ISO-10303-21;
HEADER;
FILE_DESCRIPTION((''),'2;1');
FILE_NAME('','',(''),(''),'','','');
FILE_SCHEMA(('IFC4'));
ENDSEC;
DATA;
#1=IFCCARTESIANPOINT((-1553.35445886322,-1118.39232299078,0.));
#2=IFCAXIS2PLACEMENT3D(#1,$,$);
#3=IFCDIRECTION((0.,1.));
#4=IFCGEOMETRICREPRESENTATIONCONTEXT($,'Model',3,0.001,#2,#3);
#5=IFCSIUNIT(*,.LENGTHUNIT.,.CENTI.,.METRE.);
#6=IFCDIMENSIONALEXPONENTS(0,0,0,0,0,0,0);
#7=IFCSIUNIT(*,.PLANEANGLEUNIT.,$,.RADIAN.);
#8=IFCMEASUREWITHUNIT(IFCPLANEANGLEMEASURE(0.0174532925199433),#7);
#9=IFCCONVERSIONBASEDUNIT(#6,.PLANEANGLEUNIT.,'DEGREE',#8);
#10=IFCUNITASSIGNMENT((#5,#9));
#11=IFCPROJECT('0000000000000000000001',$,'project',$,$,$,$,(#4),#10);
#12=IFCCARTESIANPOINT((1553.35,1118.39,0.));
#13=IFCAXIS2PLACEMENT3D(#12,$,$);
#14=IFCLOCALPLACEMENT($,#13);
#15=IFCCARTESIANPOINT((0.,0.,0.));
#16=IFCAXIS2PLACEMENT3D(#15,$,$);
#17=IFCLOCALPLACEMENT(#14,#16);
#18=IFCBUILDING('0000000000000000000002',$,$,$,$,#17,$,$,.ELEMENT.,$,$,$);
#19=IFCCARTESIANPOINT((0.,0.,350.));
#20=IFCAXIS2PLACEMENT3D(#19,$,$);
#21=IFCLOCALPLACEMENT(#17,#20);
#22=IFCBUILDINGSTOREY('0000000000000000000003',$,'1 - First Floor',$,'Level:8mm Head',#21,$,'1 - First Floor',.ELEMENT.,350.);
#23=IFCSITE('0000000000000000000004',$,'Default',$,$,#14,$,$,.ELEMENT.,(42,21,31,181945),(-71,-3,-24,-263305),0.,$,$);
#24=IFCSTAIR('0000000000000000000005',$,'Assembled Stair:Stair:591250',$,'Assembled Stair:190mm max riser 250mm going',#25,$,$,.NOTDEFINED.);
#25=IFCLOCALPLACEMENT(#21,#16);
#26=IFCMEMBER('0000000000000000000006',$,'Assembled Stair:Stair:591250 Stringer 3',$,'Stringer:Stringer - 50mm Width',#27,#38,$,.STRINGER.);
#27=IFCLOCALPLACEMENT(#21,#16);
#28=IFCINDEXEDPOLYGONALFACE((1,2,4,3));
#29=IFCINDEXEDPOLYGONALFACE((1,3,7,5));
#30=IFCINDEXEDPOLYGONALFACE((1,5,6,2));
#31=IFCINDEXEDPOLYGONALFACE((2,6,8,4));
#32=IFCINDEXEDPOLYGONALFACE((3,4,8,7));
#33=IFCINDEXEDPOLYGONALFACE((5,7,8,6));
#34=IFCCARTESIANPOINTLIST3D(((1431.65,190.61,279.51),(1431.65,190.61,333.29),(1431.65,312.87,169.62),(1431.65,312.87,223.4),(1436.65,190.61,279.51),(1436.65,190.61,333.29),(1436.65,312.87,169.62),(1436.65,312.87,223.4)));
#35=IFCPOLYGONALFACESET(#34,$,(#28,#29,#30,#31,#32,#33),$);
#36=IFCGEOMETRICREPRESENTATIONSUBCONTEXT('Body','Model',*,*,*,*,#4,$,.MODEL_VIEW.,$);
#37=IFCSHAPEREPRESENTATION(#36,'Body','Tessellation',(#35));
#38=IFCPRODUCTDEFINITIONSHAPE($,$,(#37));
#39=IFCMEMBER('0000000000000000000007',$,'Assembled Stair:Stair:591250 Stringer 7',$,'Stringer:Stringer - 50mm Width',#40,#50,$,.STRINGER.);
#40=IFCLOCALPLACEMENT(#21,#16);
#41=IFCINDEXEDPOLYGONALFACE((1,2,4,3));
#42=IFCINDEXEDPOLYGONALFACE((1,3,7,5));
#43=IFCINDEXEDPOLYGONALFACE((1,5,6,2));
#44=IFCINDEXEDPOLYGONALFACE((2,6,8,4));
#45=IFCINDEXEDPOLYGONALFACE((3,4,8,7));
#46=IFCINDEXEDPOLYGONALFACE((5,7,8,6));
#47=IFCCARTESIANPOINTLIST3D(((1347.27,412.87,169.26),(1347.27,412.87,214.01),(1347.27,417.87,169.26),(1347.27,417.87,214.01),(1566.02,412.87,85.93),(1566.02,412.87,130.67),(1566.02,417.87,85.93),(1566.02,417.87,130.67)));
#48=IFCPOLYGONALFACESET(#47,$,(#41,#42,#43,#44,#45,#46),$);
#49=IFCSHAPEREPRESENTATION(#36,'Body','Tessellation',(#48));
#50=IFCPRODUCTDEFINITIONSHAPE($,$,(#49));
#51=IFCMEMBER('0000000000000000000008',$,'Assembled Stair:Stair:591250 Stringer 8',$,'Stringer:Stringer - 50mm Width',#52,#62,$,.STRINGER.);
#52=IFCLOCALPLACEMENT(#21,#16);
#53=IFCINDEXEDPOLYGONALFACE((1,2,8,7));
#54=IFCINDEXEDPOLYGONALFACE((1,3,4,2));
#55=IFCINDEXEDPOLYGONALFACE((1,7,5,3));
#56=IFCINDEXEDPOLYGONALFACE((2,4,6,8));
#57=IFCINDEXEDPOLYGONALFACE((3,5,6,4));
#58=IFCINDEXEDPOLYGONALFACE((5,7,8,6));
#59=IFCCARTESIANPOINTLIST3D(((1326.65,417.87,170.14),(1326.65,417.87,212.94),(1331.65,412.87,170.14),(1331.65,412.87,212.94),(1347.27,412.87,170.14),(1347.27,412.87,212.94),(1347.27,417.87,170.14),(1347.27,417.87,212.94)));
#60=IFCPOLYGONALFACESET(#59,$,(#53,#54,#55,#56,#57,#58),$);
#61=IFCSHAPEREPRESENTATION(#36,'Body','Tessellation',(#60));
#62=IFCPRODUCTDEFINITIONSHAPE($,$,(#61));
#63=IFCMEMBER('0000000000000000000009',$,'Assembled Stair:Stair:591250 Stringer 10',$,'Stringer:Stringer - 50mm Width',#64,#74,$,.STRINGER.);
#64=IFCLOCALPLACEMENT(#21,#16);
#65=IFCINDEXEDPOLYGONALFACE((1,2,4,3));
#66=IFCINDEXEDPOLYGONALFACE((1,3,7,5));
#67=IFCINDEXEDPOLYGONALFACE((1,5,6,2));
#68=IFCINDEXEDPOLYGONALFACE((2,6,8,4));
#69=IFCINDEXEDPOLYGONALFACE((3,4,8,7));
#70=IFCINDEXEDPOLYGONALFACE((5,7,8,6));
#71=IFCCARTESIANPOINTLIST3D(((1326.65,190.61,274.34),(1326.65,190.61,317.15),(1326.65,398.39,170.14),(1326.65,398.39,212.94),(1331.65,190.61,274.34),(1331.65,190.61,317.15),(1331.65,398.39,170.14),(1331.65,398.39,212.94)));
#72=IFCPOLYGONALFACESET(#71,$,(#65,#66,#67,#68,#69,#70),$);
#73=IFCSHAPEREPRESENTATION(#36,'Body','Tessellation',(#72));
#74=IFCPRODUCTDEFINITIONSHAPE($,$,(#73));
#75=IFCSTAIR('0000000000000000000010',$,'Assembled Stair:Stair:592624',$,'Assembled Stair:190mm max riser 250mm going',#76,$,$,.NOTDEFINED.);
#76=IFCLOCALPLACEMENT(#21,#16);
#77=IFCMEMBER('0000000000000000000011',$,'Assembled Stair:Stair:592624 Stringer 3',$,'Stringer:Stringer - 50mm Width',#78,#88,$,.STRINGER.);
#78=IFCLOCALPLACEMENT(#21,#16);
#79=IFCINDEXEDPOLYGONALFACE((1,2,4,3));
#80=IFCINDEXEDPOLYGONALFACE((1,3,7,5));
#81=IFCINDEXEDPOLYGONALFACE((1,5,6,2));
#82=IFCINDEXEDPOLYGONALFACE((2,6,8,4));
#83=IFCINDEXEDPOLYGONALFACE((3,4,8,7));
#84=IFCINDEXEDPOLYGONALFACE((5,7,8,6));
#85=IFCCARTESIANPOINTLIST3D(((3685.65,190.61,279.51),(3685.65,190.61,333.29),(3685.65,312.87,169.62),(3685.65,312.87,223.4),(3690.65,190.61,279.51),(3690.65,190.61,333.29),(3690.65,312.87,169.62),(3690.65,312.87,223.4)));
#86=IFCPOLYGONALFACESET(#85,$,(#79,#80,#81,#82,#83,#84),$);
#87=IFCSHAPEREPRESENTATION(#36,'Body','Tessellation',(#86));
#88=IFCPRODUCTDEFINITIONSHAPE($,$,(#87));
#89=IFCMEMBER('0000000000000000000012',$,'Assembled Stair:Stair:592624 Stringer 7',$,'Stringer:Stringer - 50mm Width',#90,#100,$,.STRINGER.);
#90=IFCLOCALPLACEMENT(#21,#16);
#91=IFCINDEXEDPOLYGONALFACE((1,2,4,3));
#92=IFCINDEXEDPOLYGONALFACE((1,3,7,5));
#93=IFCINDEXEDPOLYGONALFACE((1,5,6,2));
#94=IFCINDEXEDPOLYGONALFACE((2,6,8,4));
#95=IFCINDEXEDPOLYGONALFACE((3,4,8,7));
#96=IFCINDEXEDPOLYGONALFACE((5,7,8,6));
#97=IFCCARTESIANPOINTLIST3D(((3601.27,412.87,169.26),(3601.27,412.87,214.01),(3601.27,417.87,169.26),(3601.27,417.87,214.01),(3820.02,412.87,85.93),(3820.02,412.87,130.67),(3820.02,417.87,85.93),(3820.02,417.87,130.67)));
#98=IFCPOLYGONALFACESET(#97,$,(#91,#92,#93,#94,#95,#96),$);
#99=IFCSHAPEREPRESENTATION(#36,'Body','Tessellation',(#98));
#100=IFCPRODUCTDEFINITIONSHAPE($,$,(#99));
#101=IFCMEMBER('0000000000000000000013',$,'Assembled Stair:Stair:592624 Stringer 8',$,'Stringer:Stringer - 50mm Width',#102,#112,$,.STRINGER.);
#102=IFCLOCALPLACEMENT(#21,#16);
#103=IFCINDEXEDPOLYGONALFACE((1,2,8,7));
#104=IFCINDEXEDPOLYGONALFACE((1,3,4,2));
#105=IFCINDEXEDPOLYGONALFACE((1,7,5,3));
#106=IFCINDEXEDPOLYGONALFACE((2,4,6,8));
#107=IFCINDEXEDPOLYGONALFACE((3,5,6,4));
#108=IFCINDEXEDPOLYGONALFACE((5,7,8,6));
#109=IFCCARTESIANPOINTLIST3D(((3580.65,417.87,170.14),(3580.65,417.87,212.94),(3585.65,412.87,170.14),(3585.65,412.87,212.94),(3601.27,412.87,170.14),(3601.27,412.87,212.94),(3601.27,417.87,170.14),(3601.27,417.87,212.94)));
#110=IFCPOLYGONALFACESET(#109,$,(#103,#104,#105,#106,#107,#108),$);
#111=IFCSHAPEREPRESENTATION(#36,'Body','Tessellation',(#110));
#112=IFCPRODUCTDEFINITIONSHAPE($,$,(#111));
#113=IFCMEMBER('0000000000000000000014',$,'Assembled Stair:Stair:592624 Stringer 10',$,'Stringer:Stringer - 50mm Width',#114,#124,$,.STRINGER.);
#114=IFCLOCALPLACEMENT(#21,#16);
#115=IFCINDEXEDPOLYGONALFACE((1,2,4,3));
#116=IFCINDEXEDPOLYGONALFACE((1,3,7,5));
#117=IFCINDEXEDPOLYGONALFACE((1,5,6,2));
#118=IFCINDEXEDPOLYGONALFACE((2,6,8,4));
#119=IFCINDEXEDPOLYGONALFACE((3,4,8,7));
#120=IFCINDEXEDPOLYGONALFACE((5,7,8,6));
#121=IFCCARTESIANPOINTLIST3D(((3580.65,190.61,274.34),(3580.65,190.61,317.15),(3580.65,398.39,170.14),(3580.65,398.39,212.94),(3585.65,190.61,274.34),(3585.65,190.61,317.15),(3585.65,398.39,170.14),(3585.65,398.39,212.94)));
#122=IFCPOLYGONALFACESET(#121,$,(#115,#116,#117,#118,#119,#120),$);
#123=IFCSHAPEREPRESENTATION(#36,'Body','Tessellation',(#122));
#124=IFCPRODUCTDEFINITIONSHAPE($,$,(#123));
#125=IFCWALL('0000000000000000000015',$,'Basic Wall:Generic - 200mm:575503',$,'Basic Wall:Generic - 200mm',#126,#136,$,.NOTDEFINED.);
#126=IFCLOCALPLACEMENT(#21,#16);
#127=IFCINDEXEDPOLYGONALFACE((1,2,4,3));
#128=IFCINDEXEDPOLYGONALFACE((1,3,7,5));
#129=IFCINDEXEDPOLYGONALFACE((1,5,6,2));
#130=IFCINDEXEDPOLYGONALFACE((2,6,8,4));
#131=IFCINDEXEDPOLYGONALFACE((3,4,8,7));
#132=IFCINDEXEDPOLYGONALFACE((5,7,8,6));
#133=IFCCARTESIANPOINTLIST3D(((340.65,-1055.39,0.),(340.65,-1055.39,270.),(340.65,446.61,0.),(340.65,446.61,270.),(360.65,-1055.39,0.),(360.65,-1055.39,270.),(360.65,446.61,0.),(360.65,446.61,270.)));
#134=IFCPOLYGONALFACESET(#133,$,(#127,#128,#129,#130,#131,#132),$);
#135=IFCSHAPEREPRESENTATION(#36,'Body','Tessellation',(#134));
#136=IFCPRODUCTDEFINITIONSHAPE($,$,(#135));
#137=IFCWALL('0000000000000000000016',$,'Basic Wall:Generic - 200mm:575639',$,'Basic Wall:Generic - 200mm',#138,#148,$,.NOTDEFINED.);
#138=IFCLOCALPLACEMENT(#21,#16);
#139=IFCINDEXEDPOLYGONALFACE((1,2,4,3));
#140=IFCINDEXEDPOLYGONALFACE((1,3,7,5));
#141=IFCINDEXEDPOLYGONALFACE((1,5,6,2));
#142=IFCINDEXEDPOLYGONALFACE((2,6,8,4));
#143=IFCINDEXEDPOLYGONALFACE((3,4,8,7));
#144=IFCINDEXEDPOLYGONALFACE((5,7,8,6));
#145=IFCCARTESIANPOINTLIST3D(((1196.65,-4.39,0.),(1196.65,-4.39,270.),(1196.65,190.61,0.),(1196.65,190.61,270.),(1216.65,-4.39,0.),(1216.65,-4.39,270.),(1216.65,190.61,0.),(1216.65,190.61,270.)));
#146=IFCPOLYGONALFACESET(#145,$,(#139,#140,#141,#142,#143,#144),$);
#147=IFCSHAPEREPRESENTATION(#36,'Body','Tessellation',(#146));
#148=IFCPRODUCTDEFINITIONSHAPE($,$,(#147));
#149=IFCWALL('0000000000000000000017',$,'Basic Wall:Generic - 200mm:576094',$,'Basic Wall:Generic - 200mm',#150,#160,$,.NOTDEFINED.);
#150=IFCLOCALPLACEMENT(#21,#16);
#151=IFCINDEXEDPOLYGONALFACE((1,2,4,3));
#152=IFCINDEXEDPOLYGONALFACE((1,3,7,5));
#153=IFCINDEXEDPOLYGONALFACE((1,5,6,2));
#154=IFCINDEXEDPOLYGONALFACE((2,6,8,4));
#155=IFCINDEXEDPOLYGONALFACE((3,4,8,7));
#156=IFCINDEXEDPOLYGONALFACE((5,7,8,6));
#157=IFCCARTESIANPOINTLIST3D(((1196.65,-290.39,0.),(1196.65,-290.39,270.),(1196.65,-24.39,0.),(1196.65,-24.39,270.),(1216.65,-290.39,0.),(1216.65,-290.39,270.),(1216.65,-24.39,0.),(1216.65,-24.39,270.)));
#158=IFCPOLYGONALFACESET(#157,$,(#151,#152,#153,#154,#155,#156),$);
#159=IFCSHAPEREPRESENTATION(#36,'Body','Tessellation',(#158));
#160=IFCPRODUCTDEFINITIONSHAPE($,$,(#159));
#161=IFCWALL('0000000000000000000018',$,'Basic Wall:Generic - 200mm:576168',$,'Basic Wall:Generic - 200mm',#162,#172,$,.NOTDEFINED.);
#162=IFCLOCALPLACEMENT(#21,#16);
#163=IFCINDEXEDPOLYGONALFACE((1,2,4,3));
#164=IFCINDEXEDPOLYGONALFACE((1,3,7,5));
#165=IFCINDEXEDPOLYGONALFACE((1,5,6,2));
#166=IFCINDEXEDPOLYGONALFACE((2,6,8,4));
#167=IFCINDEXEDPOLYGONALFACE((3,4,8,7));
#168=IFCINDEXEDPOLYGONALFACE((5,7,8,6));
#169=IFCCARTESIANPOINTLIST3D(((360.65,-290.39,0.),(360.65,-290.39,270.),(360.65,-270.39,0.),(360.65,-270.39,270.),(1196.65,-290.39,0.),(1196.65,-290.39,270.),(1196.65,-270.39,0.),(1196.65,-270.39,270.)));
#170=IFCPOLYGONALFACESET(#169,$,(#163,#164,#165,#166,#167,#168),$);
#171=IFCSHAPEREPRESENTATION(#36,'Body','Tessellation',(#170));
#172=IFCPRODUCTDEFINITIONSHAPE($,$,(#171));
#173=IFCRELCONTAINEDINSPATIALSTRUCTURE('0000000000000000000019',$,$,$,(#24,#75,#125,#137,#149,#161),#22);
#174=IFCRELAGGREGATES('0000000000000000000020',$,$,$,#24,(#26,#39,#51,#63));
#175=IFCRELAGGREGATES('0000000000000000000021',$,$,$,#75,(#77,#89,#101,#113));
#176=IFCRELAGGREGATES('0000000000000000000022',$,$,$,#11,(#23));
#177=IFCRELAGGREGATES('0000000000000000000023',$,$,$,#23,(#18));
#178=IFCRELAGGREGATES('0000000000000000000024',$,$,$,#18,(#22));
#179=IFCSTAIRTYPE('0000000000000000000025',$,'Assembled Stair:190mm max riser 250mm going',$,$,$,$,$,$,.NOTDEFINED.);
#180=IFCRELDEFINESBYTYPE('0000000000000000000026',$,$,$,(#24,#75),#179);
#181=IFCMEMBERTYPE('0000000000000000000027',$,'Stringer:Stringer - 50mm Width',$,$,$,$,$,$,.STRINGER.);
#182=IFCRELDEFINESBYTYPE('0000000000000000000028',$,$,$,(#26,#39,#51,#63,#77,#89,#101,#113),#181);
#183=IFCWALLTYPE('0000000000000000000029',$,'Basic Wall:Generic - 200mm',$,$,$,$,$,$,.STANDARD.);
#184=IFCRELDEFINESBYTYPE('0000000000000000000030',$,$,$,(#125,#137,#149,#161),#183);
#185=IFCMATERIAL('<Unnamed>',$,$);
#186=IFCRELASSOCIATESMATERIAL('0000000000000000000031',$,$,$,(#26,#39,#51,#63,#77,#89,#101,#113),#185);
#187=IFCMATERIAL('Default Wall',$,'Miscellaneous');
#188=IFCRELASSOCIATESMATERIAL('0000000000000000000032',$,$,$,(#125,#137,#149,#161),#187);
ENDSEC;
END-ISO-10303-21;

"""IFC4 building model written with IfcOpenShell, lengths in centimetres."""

from ifc_helpers import new_model, entity, si_unit, converted_unit, direction, frame, origin, place, context, subcontext, project, spatial, indexed_curve, outline, extrude, material, type_object, element, aggregate, save


model = new_model("IFC4")

# Units and contexts
model_context = context("Model", 3, precision=0.001, world=frame((-1553.35445886322, -1118.39232299078, 0.0)), true_north=direction((0.0, 1.0)))
body_context = subcontext(model_context, "Body", "Model", "MODEL_VIEW")
ifc_project = project(units=[si_unit("LENGTHUNIT", "METRE", prefix="CENTI"), converted_unit("PLANEANGLEUNIT", "DEGREE", entity("IfcPlaneAngleMeasure", 0.0174532925199433), si_unit("PLANEANGLEUNIT", "RADIAN"), dimensions=[0, 0, 0, 0, 0, 0, 0])], contexts=[model_context])

# Site, building, storey
site_placement = place(None, frame((1553.35, 1118.39, 0.0)))
site = spatial("IfcSite", under=ifc_project, at=site_placement, Name="Default", CompositionType="ELEMENT", RefLatitude=(42, 21, 31, 181945), RefLongitude=(-71, -3, -24, -263305), RefElevation=0.0)
building_placement = place(site_placement, origin())
building = spatial("IfcBuilding", under=site, at=building_placement, CompositionType="ELEMENT")
storey_placement = place(building_placement, frame((0.0, 0.0, 350.0)))
storey = spatial("IfcBuildingStorey", under=building, at=storey_placement, Name="1 - First Floor", ObjectType="Level:8mm Head", LongName="1 - First Floor", CompositionType="ELEMENT", Elevation=350.0)

# Stairs, members
stair_type = type_object("IfcStairType", Name="Assembled Stair:190mm max riser 250mm going", PredefinedType="NOTDEFINED")
stair_1_placement = place(storey_placement, origin())
stair_1 = element("IfcStair", 1, at=stair_1_placement, inside=storey, type_object=stair_type, Name="Assembled Stair:Stair:591250", ObjectType="Assembled Stair:190mm max riser 250mm going", PredefinedType="NOTDEFINED")
ifc_material_1 = material(Name="<Unnamed>")
member_type = type_object("IfcMemberType", Name="Stringer:Stringer - 50mm Width", PredefinedType="STRINGER")
member_1_placement = place(stair_1_placement, origin())
member_1 = element("IfcMember", 2, at=member_1_placement, type_object=member_type, material=ifc_material_1, Name="Assembled Stair:Stair:591250 Stringer 3", ObjectType="Stringer:Stringer - 50mm Width", PredefinedType="STRINGER", context=body_context, shape_type="SweptSolid", body=[
    extrude(outline(indexed_curve([(-64.22, -20.0), (100.17, -20.0), (64.22, 20.0), (-100.17, 20.0), (-64.22, -20.0)], self_intersect=False)), frame((1431.65, 251.74, 251.46), z_axis=(1.0, 0.0, 0.0), x_axis=(0.0, -0.74373, 0.668481)), (0.0, 0.0, 1.0), 5.0),
])
member_2_placement = place(stair_1_placement, origin())
member_2 = element("IfcMember", 3, at=member_2_placement, type_object=member_type, material=ifc_material_1, Name="Assembled Stair:Stair:591250 Stringer 7", ObjectType="Stringer:Stringer - 50mm Width", PredefinedType="STRINGER", context=body_context, shape_type="SweptSolid", body=[
    extrude(outline(indexed_curve([(-125.01, -20.91), (109.08, -20.91), (125.01, 20.91), (-109.08, 20.91), (-125.01, -20.91)], self_intersect=False)), frame((1456.65, 412.87, 149.97), z_axis=(0.0, 1.0, 0.0), x_axis=(-0.934489, 0.0, 0.355992)), (0.0, 0.0, 1.0), 5.0),
])
member_3_placement = place(stair_1_placement, origin())
member_3 = element("IfcMember", 4, at=member_3_placement, type_object=member_type, material=ifc_material_1, Name="Assembled Stair:Stair:591250 Stringer 8", ObjectType="Stringer:Stringer - 50mm Width", PredefinedType="STRINGER", context=body_context, shape_type="SweptSolid", body=[
    extrude(outline(indexed_curve([(-9.06, -2.5), (11.56, -2.5), (6.56, 2.5), (-9.06, 2.5), (-9.06, -2.5)], self_intersect=False)), frame((1338.21, 415.37, 170.14), z_axis=(0.0, 0.0, 1.0), x_axis=(-1.0, 0.0, 0.0)), (0.0, 0.0, 1.0), 42.8),
])
member_4_placement = place(stair_1_placement, origin())
member_4 = element("IfcMember", 5, at=member_4_placement, type_object=member_type, material=ifc_material_1, Name="Assembled Stair:Stair:591250 Stringer 10", ObjectType="Stringer:Stringer - 50mm Width", PredefinedType="STRINGER", context=body_context, shape_type="SweptSolid", body=[
    extrude(outline(indexed_curve([(-106.63, -19.13), (125.82, -19.13), (106.63, 19.13), (-125.82, 19.13), (-106.63, -19.13)], self_intersect=False)), frame((1326.65, 294.5, 243.64), z_axis=(1.0, 0.0, 0.0), x_axis=(0.0, -0.893886, 0.448294)), (0.0, 0.0, 1.0), 5.0),
])
aggregate(stair_1, [member_1, member_2, member_3, member_4])
stair_2_placement = place(storey_placement, origin())
stair_2 = element("IfcStair", 6, at=stair_2_placement, inside=storey, type_object=stair_type, Name="Assembled Stair:Stair:592624", ObjectType="Assembled Stair:190mm max riser 250mm going", PredefinedType="NOTDEFINED")
member_5_placement = place(stair_2_placement, origin())
member_5 = element("IfcMember", 7, at=member_5_placement, type_object=member_type, material=ifc_material_1, Name="Assembled Stair:Stair:592624 Stringer 3", ObjectType="Stringer:Stringer - 50mm Width", PredefinedType="STRINGER", context=body_context, shape_type="SweptSolid", body=[
    extrude(outline(indexed_curve([(-64.22, -20.0), (100.17, -20.0), (64.22, 20.0), (-100.17, 20.0), (-64.22, -20.0)], self_intersect=False)), frame((3685.65, 251.74, 251.46), z_axis=(1.0, 0.0, 0.0), x_axis=(0.0, -0.74373, 0.668481)), (0.0, 0.0, 1.0), 5.0),
])
member_6_placement = place(stair_2_placement, origin())
member_6 = element("IfcMember", 8, at=member_6_placement, type_object=member_type, material=ifc_material_1, Name="Assembled Stair:Stair:592624 Stringer 7", ObjectType="Stringer:Stringer - 50mm Width", PredefinedType="STRINGER", context=body_context, shape_type="SweptSolid", body=[
    extrude(outline(indexed_curve([(-125.01, -20.91), (109.08, -20.91), (125.01, 20.91), (-109.08, 20.91), (-125.01, -20.91)], self_intersect=False)), frame((3710.65, 412.87, 149.97), z_axis=(0.0, 1.0, 0.0), x_axis=(-0.934489, 0.0, 0.355992)), (0.0, 0.0, 1.0), 5.0),
])
member_7_placement = place(stair_2_placement, origin())
member_7 = element("IfcMember", 9, at=member_7_placement, type_object=member_type, material=ifc_material_1, Name="Assembled Stair:Stair:592624 Stringer 8", ObjectType="Stringer:Stringer - 50mm Width", PredefinedType="STRINGER", context=body_context, shape_type="SweptSolid", body=[
    extrude(outline(indexed_curve([(-9.06, -2.5), (11.56, -2.5), (6.56, 2.5), (-9.06, 2.5), (-9.06, -2.5)], self_intersect=False)), frame((3592.21, 415.37, 170.14), z_axis=(0.0, 0.0, 1.0), x_axis=(-1.0, 0.0, 0.0)), (0.0, 0.0, 1.0), 42.8),
])
member_8_placement = place(stair_2_placement, origin())
member_8 = element("IfcMember", 10, at=member_8_placement, type_object=member_type, material=ifc_material_1, Name="Assembled Stair:Stair:592624 Stringer 10", ObjectType="Stringer:Stringer - 50mm Width", PredefinedType="STRINGER", context=body_context, shape_type="SweptSolid", body=[
    extrude(outline(indexed_curve([(-106.63, -19.13), (125.82, -19.13), (106.63, 19.13), (-125.82, 19.13), (-106.63, -19.13)], self_intersect=False)), frame((3580.65, 294.5, 243.64), z_axis=(1.0, 0.0, 0.0), x_axis=(0.0, -0.893886, 0.448294)), (0.0, 0.0, 1.0), 5.0),
])

# Walls
ifc_material_2 = material(Name="Default Wall", Category="Miscellaneous")
wall_type = type_object("IfcWallType", Name="Basic Wall:Generic - 200mm", PredefinedType="STANDARD")
wall_1_placement = place(storey_placement, frame((350.65, 446.61, 0.0), z_axis=(0.0, 0.0, 1.0), x_axis=(0.0, -1.0, 0.0)))
element("IfcWall", 11, at=wall_1_placement, inside=storey, type_object=wall_type, material=ifc_material_2, Name="Basic Wall:Generic - 200mm:575503", ObjectType="Basic Wall:Generic - 200mm", PredefinedType="NOTDEFINED", context=body_context, shape_type="SweptSolid", body=[
    extrude(outline(indexed_curve([(1502.0, 10.0), (0.0, 10.0), (0.0, -10.0), (1502.0, -10.0), (1502.0, 10.0)], self_intersect=False)), origin(), (0.0, 0.0, 1.0), 270.0),
])
wall_2_placement = place(storey_placement, frame((1206.65, -4.39, 0.0), z_axis=(0.0, 0.0, 1.0), x_axis=(0.0, 1.0, 0.0)))
element("IfcWall", 12, at=wall_2_placement, inside=storey, type_object=wall_type, material=ifc_material_2, Name="Basic Wall:Generic - 200mm:575639", ObjectType="Basic Wall:Generic - 200mm", PredefinedType="NOTDEFINED", context=body_context, shape_type="SweptSolid", body=[
    extrude(outline(indexed_curve([(195.0, 10.0), (0.0, 10.0), (0.0, -10.0), (195.0, -10.0), (195.0, 10.0)], self_intersect=False)), origin(), (0.0, 0.0, 1.0), 270.0),
])
wall_3_placement = place(storey_placement, frame((1206.65, -24.39, 0.0), z_axis=(0.0, 0.0, 1.0), x_axis=(0.0, -1.0, 0.0)))
element("IfcWall", 13, at=wall_3_placement, inside=storey, type_object=wall_type, material=ifc_material_2, Name="Basic Wall:Generic - 200mm:576094", ObjectType="Basic Wall:Generic - 200mm", PredefinedType="NOTDEFINED", context=body_context, shape_type="SweptSolid", body=[
    extrude(outline(indexed_curve([(266.0, 10.0), (0.0, 10.0), (0.0, -10.0), (266.0, -10.0), (266.0, 10.0)], self_intersect=False)), origin(), (0.0, 0.0, 1.0), 270.0),
])
wall_4_placement = place(storey_placement, frame((1196.65, -280.39, 0.0), z_axis=(0.0, 0.0, 1.0), x_axis=(-1.0, 0.0, 0.0)))
element("IfcWall", 14, at=wall_4_placement, inside=storey, type_object=wall_type, material=ifc_material_2, Name="Basic Wall:Generic - 200mm:576168", ObjectType="Basic Wall:Generic - 200mm", PredefinedType="NOTDEFINED", context=body_context, shape_type="SweptSolid", body=[
    extrude(outline(indexed_curve([(836.0, 10.0), (0.0, 10.0), (0.0, -10.0), (836.0, -10.0), (836.0, 10.0)], self_intersect=False)), origin(), (0.0, 0.0, 1.0), 270.0),
])

aggregate(stair_2, [member_5, member_6, member_7, member_8])

save(model, "model.ifc")
